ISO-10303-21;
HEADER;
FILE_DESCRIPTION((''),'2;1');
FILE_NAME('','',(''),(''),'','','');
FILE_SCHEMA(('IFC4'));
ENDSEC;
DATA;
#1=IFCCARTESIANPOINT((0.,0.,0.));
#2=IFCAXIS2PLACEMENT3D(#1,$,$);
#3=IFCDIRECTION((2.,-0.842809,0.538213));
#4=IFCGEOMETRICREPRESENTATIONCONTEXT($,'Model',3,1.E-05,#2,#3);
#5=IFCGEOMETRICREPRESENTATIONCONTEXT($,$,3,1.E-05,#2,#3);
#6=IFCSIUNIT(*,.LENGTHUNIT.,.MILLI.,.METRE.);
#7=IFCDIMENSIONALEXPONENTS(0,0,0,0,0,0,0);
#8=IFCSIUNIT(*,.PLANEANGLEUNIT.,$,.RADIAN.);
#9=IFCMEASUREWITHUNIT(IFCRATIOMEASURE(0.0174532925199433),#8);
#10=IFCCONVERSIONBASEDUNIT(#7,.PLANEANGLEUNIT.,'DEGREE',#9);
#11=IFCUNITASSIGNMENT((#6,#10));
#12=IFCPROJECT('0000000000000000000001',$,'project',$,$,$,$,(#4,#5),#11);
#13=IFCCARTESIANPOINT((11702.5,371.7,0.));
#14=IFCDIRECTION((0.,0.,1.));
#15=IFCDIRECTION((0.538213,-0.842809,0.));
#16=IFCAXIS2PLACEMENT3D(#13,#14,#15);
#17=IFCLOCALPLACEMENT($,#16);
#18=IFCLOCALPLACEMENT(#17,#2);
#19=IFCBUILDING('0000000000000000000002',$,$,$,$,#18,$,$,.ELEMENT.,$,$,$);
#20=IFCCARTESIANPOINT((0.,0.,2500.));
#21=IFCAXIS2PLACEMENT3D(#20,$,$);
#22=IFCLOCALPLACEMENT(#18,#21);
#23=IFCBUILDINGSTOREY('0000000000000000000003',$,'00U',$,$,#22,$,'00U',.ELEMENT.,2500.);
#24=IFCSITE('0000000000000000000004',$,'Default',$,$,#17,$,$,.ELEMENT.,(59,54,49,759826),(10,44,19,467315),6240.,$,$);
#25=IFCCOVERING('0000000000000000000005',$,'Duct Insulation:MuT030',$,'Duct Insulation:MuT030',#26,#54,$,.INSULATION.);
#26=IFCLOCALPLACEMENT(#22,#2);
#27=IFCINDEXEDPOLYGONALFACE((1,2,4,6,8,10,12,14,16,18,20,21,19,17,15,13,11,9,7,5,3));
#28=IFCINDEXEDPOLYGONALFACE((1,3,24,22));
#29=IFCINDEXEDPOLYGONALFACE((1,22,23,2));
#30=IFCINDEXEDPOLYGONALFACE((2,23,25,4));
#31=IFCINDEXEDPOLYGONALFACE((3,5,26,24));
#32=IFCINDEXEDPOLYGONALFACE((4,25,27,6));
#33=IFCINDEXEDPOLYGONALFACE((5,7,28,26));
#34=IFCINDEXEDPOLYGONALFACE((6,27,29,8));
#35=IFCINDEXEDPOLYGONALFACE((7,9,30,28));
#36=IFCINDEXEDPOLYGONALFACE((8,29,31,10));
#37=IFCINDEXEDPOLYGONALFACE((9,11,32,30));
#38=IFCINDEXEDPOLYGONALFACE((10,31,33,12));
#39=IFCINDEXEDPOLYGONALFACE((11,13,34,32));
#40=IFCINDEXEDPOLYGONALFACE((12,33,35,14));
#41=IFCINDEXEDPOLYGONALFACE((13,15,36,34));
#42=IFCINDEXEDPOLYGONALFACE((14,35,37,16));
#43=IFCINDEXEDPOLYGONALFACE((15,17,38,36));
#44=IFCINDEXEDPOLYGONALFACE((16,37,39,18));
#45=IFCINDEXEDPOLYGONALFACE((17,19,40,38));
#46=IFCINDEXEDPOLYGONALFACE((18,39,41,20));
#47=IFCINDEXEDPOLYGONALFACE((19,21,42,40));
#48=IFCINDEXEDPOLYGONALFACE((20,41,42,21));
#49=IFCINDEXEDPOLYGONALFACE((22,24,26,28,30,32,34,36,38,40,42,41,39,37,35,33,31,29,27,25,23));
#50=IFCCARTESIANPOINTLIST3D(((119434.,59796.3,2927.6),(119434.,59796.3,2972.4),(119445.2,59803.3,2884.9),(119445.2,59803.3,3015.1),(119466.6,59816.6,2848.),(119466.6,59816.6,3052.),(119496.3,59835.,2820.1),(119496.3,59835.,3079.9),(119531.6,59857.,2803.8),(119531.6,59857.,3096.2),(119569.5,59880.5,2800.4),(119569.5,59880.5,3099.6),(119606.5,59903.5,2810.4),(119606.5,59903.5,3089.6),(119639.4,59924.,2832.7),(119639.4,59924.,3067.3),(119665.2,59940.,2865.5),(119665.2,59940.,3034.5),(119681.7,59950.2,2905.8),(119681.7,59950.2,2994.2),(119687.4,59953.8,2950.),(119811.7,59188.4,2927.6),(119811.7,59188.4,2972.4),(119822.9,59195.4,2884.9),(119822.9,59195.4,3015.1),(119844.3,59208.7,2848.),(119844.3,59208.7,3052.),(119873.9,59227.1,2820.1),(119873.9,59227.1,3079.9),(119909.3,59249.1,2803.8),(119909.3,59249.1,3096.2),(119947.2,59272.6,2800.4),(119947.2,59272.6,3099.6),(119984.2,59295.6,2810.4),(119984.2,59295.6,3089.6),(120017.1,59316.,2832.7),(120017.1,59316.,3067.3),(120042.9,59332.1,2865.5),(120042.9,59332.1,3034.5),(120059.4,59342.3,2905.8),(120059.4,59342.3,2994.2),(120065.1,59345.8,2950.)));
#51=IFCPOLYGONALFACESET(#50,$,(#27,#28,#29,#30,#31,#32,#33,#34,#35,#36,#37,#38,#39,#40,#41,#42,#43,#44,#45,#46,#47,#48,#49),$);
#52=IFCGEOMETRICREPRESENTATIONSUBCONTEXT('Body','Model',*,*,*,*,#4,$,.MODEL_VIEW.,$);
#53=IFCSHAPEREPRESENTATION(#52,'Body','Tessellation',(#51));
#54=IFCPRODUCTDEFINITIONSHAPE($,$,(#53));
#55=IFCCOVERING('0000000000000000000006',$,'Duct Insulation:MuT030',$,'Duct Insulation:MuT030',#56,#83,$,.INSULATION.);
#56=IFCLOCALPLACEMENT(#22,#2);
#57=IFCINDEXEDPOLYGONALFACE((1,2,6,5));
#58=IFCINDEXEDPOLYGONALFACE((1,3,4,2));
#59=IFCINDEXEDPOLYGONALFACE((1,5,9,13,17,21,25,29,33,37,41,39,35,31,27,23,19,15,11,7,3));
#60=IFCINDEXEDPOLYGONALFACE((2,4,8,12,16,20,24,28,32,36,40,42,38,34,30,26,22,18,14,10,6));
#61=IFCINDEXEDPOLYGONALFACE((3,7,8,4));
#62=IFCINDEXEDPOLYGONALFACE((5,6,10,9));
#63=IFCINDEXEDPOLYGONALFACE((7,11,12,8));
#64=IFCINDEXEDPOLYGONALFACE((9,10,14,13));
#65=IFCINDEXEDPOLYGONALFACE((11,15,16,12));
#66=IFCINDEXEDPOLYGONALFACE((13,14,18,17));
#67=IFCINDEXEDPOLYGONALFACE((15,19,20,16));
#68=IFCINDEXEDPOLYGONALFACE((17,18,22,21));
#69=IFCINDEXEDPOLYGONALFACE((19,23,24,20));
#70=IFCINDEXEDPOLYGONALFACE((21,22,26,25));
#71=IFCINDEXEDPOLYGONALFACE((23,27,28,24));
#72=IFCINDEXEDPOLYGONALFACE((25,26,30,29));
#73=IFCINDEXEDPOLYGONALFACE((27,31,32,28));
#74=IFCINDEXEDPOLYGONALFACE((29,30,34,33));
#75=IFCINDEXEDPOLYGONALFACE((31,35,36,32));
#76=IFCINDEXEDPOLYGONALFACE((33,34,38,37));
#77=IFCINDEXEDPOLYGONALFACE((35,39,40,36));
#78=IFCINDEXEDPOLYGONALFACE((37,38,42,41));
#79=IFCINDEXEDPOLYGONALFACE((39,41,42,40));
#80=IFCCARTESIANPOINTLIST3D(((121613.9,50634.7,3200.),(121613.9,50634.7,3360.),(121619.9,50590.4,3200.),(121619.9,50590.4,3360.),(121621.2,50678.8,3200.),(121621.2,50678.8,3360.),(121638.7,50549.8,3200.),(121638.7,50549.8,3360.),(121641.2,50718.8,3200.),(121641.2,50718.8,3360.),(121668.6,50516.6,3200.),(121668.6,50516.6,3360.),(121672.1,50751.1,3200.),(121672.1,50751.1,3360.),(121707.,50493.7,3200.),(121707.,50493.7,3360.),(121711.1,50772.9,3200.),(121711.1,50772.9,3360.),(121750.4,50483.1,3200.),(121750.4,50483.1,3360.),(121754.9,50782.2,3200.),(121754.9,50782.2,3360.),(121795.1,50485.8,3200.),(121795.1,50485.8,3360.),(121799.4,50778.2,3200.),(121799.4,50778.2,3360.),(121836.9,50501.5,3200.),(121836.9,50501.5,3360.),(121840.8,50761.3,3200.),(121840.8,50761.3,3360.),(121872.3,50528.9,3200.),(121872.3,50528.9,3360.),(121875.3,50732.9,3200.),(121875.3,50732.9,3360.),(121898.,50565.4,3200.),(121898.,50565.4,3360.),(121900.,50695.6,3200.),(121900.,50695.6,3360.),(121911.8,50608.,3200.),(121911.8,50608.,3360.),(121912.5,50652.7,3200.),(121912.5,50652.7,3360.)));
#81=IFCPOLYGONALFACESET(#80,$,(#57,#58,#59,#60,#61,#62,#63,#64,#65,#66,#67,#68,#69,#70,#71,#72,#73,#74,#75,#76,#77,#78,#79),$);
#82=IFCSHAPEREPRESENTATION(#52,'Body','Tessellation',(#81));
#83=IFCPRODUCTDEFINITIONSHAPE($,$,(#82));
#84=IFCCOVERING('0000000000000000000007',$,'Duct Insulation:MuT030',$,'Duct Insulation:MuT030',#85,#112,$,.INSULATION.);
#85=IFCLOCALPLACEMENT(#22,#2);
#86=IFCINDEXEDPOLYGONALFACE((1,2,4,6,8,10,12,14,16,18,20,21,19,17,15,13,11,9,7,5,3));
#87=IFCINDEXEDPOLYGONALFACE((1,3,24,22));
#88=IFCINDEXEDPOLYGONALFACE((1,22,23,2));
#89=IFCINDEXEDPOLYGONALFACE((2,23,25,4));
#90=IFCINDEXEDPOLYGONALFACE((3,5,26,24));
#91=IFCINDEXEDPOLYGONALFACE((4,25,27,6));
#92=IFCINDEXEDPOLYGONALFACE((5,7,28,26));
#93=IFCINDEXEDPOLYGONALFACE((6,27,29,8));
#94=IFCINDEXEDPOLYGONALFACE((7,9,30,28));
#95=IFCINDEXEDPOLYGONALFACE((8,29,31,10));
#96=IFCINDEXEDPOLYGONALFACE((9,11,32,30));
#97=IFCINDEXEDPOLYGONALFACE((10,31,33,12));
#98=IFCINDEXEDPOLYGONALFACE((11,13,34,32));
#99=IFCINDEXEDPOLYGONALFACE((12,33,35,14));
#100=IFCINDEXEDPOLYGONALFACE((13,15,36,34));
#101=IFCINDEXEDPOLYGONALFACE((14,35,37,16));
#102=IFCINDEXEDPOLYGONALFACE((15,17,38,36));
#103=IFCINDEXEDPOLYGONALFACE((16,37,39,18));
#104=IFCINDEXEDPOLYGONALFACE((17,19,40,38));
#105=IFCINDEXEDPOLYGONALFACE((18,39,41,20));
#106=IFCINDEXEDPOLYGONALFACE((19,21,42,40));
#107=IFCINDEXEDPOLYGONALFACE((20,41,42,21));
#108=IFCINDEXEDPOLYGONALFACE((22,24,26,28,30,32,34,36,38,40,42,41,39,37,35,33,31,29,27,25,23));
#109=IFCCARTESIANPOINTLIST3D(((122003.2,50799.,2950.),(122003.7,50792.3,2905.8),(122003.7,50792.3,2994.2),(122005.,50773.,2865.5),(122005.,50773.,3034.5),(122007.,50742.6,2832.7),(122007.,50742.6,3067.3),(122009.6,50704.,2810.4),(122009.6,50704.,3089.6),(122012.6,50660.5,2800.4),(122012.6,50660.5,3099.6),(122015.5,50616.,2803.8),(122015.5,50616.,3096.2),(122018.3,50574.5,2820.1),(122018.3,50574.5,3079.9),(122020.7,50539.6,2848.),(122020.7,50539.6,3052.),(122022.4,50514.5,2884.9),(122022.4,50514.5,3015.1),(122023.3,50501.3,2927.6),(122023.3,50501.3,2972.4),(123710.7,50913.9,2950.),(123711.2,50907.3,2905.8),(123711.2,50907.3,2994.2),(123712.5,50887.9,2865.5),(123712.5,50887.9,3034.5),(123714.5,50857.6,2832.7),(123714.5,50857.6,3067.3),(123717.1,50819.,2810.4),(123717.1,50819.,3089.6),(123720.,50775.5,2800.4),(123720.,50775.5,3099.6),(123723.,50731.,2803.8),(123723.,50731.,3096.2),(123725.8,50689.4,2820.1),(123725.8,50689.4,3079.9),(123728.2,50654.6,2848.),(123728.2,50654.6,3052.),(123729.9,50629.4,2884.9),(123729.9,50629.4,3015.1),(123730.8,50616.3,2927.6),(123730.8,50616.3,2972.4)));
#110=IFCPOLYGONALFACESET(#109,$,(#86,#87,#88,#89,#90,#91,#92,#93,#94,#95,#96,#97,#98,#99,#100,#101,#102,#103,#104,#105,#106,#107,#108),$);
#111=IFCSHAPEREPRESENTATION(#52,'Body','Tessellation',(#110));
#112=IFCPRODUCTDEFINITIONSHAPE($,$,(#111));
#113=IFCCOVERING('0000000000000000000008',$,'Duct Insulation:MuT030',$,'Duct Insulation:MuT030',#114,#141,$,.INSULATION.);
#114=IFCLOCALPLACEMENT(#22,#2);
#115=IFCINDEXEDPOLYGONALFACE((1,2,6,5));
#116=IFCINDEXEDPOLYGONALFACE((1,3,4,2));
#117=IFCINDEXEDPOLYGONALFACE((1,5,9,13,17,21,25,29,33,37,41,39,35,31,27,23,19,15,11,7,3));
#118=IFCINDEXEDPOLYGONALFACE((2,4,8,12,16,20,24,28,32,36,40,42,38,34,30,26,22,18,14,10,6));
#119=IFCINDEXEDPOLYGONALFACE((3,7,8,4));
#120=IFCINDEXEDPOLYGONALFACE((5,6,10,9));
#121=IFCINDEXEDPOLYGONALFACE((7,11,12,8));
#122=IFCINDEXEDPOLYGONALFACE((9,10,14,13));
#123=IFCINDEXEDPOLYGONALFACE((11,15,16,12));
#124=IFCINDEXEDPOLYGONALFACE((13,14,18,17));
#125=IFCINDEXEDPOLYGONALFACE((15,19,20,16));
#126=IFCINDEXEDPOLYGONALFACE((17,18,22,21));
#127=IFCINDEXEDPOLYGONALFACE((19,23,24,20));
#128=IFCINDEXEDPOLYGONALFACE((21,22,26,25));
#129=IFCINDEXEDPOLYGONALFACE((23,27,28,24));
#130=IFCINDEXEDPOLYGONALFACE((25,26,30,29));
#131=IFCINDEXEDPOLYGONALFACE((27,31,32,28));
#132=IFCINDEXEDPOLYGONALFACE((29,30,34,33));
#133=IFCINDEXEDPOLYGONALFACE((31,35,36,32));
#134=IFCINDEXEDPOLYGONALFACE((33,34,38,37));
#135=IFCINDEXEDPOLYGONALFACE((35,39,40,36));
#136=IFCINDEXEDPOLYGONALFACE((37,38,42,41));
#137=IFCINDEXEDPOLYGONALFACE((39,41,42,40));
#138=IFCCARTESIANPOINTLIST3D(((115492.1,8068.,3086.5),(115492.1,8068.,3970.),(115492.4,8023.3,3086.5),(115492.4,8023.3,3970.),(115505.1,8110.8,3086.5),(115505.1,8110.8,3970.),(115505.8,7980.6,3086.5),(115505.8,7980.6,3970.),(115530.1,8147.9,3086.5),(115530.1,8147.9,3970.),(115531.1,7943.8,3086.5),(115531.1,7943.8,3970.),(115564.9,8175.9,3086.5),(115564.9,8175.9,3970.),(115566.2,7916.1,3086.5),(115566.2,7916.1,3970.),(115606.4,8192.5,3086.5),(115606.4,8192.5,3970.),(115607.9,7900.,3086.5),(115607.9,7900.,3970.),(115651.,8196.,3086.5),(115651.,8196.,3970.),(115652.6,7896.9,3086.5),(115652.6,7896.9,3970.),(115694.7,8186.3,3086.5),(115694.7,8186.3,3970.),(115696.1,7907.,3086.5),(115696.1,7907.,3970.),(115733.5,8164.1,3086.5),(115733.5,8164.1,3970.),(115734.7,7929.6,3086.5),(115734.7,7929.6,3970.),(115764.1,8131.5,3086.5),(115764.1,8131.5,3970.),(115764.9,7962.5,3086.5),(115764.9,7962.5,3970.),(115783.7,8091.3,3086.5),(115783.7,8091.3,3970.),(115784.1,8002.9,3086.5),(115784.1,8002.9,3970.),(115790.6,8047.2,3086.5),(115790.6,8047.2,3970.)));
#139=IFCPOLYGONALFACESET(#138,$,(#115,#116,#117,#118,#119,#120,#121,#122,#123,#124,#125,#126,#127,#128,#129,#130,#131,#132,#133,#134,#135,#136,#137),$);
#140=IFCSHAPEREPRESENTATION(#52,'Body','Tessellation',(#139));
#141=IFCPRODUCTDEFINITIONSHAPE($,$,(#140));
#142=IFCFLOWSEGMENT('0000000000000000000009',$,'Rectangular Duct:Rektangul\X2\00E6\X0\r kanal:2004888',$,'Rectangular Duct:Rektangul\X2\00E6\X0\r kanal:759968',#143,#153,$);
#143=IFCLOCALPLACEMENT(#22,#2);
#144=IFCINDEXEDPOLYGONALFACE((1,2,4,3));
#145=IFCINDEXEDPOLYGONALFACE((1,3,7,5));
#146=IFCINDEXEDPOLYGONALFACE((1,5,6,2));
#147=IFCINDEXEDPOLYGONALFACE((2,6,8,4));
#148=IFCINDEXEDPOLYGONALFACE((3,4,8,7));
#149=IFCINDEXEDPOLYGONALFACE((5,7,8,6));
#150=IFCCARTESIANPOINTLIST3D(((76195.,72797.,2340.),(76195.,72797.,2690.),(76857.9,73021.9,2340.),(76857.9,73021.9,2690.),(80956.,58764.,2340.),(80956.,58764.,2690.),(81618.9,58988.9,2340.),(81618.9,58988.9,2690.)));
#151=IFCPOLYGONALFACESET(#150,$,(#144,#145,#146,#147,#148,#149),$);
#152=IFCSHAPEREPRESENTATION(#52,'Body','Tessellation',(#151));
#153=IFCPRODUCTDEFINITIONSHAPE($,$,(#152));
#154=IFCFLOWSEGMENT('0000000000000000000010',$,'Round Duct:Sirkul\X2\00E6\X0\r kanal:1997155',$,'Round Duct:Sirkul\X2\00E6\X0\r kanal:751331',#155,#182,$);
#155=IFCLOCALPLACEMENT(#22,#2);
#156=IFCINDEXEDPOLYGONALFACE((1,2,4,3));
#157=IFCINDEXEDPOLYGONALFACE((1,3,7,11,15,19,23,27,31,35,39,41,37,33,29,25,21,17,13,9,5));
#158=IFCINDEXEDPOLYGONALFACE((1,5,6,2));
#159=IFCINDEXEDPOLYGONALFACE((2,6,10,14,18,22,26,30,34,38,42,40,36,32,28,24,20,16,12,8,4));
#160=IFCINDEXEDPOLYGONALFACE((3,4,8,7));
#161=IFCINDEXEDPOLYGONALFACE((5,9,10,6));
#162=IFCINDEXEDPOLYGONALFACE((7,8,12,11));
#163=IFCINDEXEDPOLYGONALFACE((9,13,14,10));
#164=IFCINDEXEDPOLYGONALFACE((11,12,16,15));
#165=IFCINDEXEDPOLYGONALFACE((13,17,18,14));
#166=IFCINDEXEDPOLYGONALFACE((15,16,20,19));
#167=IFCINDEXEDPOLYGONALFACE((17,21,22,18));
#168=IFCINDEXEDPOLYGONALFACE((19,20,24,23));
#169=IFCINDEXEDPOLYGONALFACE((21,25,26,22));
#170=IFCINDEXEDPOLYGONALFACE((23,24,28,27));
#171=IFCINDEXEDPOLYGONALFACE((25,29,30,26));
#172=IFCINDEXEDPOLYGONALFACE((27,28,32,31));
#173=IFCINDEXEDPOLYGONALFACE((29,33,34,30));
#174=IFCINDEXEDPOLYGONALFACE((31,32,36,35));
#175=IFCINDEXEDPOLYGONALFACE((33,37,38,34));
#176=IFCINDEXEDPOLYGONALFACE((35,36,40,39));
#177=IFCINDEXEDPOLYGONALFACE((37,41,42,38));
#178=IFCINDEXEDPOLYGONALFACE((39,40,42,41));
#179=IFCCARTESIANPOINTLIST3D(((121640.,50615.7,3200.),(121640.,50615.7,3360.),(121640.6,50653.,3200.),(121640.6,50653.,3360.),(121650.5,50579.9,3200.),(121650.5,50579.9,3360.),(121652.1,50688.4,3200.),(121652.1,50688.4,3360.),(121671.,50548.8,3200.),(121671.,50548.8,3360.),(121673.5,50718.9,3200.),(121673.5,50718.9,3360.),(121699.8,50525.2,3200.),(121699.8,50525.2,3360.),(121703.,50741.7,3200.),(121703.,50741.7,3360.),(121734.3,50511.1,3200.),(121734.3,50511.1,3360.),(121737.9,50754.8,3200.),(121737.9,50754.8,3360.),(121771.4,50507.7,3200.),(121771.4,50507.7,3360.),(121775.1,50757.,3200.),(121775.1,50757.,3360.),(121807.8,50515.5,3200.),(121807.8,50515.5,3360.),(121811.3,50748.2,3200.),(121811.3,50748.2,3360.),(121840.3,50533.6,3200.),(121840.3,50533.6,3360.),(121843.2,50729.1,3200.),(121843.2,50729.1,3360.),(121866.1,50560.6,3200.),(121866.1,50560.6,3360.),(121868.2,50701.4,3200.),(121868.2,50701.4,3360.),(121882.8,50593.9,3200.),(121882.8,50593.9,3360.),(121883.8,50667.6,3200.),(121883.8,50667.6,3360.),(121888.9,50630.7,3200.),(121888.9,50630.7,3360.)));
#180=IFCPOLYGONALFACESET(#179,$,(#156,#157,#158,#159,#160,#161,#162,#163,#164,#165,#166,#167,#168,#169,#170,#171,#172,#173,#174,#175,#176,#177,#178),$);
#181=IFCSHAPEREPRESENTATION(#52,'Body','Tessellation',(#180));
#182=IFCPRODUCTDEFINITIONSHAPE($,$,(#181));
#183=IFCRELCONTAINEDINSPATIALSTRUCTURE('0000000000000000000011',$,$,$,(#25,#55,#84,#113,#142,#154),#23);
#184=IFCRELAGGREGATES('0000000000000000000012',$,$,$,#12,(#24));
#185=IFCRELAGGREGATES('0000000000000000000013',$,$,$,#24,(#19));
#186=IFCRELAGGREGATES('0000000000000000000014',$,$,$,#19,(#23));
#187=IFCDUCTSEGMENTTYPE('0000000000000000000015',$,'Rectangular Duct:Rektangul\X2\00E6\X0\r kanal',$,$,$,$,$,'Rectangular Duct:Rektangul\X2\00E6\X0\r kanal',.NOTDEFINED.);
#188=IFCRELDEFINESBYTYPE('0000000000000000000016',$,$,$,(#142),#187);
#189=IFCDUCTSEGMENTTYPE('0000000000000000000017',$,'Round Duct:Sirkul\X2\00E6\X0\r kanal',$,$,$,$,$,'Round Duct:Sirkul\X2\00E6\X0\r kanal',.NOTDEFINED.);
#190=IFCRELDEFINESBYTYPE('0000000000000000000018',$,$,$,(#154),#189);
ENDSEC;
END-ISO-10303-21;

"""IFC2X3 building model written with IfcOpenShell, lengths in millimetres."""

from ifc_helpers import new_model, entity, si_unit, converted_unit, direction, frame, frame_2d, origin, origin_2d_with_axis, place, context, subcontext, project, spatial, rectangle, circle, extrude, type_object, element, save


model = new_model("IFC2X3")

# Units and contexts
model_context = context("Model", 3, precision=1e-05, world=origin(), true_north=direction((2.0, -0.842809, 0.538213)))
context_of_model = context(None, 3, precision=1e-05, world=origin(), true_north=direction((2.0, -0.842809, 0.538213)))
body_context = subcontext(model_context, "Body", "Model", "MODEL_VIEW")
ifc_project = project(units=[si_unit("LENGTHUNIT", "METRE", prefix="MILLI"), converted_unit("PLANEANGLEUNIT", "DEGREE", entity("IfcRatioMeasure", 0.0174532925199433), si_unit("PLANEANGLEUNIT", "RADIAN"), dimensions=[0, 0, 0, 0, 0, 0, 0])], contexts=[model_context, context_of_model])

# Site, building, storey
site_placement = place(None, frame((11702.5, 371.7, 0.0), z_axis=(0.0, 0.0, 1.0), x_axis=(0.538213, -0.842809, 0.0)))
site = spatial("IfcSite", under=ifc_project, at=site_placement, Name="Default", CompositionType="ELEMENT", RefLatitude=(59, 54, 49, 759826), RefLongitude=(10, 44, 19, 467315), RefElevation=6240.0)
building_placement = place(site_placement, origin())
building = spatial("IfcBuilding", under=site, at=building_placement, CompositionType="ELEMENT")
storey_placement = place(building_placement, frame((0.0, 0.0, 2500.0)))
storey = spatial("IfcBuildingStorey", under=building, at=storey_placement, Name="00U", LongName="00U", CompositionType="ELEMENT", Elevation=2500.0)

# Coverings
covering_1_placement = place(storey_placement, origin())
element("IfcCovering", 1, at=covering_1_placement, inside=storey, Name="Duct Insulation:MuT030", ObjectType="Duct Insulation:MuT030", PredefinedType="INSULATION", context=body_context, shape_type="SweptSolid", body=[
    extrude(circle(Radius=150.0, at=origin_2d_with_axis()), frame((119560.0, 59874.6, 2950.0), z_axis=(0.527732, -0.849411, 0.0), x_axis=(0.849411, 0.527732, 0.0)), (0.0, 0.0, 1.0), 715.7),
])
covering_2_placement = place(storey_placement, origin())
element("IfcCovering", 2, at=covering_2_placement, inside=storey, Name="Duct Insulation:MuT030", ObjectType="Duct Insulation:MuT030", PredefinedType="INSULATION", context=body_context, shape_type="SweptSolid", body=[
    extrude(circle(Radius=150.0, at=origin_2d_with_axis()), frame((121763.9, 50632.5, 3200.0), z_axis=(0.0, 0.0, 1.0), x_axis=(-0.059967, 0.9982, 0.0)), (0.0, 0.0, 1.0), 160.0),
])
covering_3_placement = place(storey_placement, origin())
element("IfcCovering", 3, at=covering_3_placement, inside=storey, Name="Duct Insulation:MuT030", ObjectType="Duct Insulation:MuT030", PredefinedType="INSULATION", context=body_context, shape_type="SweptSolid", body=[
    extrude(circle(Radius=150.0, at=origin_2d_with_axis()), frame((122013.3, 50649.3, 2950.0), z_axis=(0.997741, 0.067185, 0.0), x_axis=(-0.067185, 0.997741, 0.0)), (0.0, 0.0, 1.0), 1711.4),
])
covering_4_placement = place(storey_placement, origin())
element("IfcCovering", 4, at=covering_4_placement, inside=storey, Name="Duct Insulation:MuT030", ObjectType="Duct Insulation:MuT030", PredefinedType="INSULATION", context=body_context, shape_type="SweptSolid", body=[
    extrude(circle(Radius=150.0, at=frame_2d((0.0, 0.0), x_axis=(1.0, 0.0))), frame((115640.6, 8046.4, 3086.5), z_axis=(0.000001, 0.0, 1.0), x_axis=(0.954042, 0.299672, -0.000001)), (0.0, 0.0, 1.0), 883.5),
])

# Flow segments
duct_segment_type_1 = type_object("IfcDuctSegmentType", Name="Rectangular Duct:Rektangulær kanal", ElementType="Rectangular Duct:Rektangulær kanal", PredefinedType="NOTDEFINED")
flow_segment_1_placement = place(storey_placement, origin())
element("IfcFlowSegment", 5, at=flow_segment_1_placement, inside=storey, type_object=duct_segment_type_1, Name="Rectangular Duct:Rektangulær kanal:2004888", ObjectType="Rectangular Duct:Rektangulær kanal:759968", context=body_context, shape_type="SweptSolid", body=[
    extrude(rectangle(XDim=14818.6, YDim=700.0, at=origin_2d_with_axis()), frame((78907.0, 65893.0, 2340.0), z_axis=(0.0, 0.0, 1.0), x_axis=(-0.321286, 0.946982, 0.0)), (0.0, 0.0, 1.0), 350.0),
])
duct_segment_type_2 = type_object("IfcDuctSegmentType", Name="Round Duct:Sirkulær kanal", ElementType="Round Duct:Sirkulær kanal", PredefinedType="NOTDEFINED")
flow_segment_2_placement = place(storey_placement, origin())
element("IfcFlowSegment", 6, at=flow_segment_2_placement, inside=storey, type_object=duct_segment_type_2, Name="Round Duct:Sirkulær kanal:1997155", ObjectType="Round Duct:Sirkulær kanal:751331", context=body_context, shape_type="SweptSolid", body=[
    extrude(circle(Radius=125.0, at=origin_2d_with_axis()), frame((121763.9, 50632.5, 3200.0), z_axis=(0.0, 0.0, 1.0), x_axis=(0.059967, -0.9982, 0.0)), (0.0, 0.0, 1.0), 160.0),
])

save(model, "model.ifc")
